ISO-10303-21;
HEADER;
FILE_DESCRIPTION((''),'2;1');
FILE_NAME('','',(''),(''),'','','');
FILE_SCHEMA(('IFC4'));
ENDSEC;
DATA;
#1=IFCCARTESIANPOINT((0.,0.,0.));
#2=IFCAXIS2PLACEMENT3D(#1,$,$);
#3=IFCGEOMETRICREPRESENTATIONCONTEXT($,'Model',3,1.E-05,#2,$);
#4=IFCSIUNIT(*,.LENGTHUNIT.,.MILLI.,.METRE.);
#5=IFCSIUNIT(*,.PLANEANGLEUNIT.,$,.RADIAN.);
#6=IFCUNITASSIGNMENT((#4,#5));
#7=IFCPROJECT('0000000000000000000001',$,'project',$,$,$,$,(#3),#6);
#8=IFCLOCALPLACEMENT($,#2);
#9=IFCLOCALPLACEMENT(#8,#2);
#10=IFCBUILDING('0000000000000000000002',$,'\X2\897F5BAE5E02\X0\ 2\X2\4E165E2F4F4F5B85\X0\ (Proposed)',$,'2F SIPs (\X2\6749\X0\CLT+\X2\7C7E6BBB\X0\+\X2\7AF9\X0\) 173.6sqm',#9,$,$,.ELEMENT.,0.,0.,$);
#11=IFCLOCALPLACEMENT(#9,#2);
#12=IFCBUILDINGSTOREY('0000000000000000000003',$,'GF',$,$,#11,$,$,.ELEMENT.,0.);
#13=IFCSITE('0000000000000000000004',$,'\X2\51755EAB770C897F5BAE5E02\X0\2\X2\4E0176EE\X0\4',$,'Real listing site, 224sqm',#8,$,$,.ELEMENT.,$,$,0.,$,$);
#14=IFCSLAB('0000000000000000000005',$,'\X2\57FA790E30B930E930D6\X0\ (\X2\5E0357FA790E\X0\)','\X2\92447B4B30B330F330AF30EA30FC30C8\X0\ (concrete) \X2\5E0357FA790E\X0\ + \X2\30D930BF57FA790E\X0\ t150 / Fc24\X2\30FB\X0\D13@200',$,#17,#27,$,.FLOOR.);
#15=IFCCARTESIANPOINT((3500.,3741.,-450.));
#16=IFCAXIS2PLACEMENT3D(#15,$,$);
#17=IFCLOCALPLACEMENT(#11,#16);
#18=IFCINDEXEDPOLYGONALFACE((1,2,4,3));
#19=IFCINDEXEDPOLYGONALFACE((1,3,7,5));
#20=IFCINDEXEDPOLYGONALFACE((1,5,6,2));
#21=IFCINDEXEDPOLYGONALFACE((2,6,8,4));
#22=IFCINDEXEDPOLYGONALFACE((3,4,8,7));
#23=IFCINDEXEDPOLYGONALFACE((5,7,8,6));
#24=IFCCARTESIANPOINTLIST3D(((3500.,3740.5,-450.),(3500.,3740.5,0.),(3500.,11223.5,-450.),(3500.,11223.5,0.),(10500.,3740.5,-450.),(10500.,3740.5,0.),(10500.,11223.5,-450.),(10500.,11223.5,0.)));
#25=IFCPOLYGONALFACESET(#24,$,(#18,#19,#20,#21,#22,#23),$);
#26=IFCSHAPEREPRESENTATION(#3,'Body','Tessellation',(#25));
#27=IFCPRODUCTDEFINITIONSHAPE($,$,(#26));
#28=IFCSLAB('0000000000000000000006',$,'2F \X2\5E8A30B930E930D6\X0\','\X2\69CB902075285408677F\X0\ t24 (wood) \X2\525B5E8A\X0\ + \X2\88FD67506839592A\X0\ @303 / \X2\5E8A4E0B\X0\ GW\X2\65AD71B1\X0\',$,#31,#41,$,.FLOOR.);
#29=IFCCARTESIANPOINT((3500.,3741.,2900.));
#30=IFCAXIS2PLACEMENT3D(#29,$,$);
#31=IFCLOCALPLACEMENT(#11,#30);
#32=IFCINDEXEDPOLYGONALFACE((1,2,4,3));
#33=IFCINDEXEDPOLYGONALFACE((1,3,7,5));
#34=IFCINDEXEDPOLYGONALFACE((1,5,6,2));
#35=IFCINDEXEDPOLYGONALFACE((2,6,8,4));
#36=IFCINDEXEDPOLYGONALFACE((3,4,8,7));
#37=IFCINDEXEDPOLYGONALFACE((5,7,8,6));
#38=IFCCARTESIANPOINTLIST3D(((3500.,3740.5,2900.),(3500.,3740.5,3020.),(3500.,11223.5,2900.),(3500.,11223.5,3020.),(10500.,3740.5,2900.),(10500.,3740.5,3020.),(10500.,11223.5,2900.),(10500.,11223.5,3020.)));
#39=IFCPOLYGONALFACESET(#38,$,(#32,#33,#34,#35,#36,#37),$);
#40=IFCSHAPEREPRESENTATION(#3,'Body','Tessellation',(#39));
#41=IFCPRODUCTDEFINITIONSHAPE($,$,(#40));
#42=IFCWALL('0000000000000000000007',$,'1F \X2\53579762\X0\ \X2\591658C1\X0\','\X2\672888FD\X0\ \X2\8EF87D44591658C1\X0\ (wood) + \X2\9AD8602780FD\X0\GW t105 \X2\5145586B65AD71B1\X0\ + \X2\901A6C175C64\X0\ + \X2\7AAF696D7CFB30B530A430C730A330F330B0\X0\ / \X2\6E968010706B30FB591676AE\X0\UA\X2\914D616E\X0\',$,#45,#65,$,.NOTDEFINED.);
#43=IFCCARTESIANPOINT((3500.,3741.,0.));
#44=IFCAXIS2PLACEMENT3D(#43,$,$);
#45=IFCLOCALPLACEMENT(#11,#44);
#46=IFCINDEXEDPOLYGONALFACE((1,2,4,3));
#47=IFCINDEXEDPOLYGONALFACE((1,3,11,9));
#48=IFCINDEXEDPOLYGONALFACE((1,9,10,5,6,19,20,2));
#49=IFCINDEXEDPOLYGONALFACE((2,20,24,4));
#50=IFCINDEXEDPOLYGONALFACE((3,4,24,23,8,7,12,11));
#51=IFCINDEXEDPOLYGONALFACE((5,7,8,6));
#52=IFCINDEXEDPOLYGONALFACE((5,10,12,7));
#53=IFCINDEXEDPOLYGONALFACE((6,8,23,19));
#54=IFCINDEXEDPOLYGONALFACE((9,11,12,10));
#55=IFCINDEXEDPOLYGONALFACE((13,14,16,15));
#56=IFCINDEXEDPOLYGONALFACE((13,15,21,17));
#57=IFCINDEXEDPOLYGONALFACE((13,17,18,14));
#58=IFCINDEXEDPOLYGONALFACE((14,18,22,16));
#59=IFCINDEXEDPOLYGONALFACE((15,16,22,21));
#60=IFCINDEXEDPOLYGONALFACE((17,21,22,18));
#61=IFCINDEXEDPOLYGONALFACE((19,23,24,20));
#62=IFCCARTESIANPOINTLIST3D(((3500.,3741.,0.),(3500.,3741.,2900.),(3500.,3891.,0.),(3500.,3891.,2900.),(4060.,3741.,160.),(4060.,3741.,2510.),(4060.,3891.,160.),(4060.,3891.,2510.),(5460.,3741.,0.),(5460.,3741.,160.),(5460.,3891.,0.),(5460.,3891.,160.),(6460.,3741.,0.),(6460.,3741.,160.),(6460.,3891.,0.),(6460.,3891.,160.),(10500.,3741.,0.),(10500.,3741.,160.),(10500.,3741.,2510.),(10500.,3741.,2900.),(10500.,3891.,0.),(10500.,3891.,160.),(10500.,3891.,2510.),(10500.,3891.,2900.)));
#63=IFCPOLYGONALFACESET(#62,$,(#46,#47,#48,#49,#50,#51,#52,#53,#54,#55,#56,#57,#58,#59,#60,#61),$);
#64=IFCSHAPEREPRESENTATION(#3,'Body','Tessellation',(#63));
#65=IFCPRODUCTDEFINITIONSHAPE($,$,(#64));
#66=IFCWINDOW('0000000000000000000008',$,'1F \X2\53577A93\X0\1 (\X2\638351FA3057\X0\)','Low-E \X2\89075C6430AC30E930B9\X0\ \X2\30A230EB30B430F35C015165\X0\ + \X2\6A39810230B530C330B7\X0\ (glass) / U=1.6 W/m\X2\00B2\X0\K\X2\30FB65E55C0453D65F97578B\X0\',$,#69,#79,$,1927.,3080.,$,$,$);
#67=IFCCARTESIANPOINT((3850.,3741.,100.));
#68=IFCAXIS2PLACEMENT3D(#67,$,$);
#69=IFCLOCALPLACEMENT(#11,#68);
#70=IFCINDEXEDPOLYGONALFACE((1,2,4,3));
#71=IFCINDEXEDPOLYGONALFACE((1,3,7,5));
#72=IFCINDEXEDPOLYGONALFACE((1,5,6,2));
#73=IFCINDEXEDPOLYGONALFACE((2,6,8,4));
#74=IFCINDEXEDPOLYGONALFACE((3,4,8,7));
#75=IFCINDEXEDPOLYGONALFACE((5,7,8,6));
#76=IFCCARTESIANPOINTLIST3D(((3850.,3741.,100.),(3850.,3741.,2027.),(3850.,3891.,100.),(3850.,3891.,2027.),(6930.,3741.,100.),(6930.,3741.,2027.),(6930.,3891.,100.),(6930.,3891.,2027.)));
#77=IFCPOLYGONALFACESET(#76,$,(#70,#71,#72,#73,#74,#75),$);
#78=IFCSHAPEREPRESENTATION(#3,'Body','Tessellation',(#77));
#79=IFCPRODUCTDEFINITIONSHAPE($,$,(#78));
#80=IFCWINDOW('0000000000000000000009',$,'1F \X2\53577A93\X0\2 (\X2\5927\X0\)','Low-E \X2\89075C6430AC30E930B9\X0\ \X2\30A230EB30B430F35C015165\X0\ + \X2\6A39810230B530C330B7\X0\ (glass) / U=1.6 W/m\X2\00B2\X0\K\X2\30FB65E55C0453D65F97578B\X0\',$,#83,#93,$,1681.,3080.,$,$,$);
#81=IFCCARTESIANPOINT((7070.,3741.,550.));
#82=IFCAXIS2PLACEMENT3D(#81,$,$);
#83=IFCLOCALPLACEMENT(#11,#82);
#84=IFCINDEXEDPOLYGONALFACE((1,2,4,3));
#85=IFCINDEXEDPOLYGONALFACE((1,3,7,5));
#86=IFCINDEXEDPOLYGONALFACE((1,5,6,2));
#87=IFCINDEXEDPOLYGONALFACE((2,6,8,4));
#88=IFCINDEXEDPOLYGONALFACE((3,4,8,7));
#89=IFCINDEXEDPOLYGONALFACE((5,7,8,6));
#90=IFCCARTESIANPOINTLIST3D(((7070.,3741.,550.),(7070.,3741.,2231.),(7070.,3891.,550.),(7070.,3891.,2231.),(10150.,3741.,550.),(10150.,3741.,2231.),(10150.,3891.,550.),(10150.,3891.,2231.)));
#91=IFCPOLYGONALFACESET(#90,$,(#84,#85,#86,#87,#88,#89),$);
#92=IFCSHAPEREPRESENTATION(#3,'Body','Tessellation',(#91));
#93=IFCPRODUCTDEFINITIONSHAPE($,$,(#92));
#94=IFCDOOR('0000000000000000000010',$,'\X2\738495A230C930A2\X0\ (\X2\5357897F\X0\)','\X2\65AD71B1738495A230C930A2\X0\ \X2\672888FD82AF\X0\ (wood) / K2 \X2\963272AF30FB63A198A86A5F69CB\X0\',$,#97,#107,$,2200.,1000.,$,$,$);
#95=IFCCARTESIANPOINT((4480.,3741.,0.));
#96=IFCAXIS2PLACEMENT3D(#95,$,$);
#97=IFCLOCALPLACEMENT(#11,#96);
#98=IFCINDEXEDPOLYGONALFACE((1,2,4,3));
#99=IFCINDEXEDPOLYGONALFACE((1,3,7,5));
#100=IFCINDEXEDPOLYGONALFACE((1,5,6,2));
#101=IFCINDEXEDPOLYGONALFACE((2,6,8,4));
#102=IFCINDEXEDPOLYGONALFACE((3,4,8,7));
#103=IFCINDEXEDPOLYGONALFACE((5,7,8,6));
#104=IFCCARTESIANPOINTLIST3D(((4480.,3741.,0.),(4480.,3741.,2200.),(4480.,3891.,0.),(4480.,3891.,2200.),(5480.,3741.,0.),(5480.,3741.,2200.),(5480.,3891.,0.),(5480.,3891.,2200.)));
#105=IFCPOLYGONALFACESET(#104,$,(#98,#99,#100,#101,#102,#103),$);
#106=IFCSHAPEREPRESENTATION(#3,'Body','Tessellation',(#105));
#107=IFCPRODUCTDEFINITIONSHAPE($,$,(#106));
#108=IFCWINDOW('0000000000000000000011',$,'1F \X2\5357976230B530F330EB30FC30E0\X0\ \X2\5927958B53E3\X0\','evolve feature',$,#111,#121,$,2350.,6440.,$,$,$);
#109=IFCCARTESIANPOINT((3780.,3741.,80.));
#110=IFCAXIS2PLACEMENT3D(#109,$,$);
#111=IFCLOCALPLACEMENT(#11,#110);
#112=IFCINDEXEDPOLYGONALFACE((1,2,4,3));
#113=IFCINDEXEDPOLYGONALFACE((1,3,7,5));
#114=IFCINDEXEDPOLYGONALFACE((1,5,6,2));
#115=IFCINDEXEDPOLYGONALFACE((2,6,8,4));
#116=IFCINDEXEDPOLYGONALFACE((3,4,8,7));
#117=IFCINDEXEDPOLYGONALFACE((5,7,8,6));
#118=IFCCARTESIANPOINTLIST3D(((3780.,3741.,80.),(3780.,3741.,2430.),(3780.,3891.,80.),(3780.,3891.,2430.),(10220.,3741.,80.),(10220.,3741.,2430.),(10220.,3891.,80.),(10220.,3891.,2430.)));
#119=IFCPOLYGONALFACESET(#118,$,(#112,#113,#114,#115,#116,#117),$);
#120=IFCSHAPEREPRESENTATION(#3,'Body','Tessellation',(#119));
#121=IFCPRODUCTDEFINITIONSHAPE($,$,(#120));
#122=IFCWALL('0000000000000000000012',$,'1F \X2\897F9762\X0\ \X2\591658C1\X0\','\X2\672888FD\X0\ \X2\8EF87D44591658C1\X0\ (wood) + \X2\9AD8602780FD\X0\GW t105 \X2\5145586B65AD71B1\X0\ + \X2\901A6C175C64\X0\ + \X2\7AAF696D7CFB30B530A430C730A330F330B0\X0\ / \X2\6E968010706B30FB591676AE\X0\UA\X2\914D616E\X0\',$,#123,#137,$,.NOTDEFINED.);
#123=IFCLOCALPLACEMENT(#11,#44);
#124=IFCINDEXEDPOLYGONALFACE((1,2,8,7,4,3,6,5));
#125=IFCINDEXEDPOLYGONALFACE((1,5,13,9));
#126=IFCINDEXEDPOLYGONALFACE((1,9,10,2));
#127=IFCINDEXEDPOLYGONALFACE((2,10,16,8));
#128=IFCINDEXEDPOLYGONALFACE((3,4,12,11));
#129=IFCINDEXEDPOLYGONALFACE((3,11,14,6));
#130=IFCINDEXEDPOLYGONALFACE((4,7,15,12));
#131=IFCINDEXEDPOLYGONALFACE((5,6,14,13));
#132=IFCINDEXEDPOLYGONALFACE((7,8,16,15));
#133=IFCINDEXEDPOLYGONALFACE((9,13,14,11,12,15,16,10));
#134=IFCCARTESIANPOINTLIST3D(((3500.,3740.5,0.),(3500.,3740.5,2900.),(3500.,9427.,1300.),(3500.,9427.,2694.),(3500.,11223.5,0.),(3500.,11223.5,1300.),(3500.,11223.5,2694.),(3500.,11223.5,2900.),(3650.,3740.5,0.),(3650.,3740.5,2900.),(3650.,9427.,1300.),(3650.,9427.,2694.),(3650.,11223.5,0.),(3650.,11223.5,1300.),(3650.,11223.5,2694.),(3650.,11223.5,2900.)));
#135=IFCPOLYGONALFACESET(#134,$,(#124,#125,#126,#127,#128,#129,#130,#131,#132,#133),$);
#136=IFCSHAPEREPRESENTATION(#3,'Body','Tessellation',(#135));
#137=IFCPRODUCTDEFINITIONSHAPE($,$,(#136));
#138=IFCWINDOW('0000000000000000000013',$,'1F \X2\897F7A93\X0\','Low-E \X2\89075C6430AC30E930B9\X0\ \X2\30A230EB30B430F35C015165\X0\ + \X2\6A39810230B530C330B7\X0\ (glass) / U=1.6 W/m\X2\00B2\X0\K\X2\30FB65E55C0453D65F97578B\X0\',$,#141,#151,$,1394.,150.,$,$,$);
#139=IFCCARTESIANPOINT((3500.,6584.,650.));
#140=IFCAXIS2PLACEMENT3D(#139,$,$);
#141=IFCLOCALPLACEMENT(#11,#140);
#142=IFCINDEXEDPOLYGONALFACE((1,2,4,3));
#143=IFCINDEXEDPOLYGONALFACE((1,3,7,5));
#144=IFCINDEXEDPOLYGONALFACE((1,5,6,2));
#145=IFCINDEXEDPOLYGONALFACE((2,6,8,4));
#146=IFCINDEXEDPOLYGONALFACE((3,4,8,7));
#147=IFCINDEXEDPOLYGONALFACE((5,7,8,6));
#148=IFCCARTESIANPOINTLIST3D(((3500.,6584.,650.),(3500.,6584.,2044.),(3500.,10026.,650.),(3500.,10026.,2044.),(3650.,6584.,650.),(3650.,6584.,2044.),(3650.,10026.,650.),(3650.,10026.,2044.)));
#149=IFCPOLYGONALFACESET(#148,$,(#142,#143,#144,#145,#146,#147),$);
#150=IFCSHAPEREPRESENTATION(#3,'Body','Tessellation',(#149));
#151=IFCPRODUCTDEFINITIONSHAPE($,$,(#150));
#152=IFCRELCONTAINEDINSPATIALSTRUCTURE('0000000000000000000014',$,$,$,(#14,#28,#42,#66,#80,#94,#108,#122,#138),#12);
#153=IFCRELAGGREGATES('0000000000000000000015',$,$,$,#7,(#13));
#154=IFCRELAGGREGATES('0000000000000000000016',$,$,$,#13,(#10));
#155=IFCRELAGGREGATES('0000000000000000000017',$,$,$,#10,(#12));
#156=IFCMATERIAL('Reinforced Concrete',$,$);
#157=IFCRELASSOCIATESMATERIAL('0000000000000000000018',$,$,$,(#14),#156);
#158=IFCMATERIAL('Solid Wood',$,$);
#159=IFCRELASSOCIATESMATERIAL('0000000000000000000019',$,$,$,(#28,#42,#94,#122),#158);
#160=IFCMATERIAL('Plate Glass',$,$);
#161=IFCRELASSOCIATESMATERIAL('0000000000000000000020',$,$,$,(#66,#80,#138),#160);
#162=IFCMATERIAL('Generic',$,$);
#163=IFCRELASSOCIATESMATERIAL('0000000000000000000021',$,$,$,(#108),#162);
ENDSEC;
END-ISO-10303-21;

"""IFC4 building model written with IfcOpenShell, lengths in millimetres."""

from ifc_helpers import new_model, si_unit, frame, frame_2d, origin, place, context, project, spatial, rectangle, extrude, material, element, fill, save


model = new_model("IFC4")

# Units and contexts
model_context = context("Model", 3, precision=1e-05, world=origin())
ifc_project = project(units=[si_unit("LENGTHUNIT", "METRE", prefix="MILLI"), si_unit("PLANEANGLEUNIT", "RADIAN")], contexts=[model_context])

# Site, building, storey
site_placement = place(None, origin())
site = spatial("IfcSite", under=ifc_project, at=site_placement, Name="兵庫県西宮市2丁目4", ObjectType="Real listing site, 224sqm", CompositionType="ELEMENT", RefElevation=0.0)
building_placement = place(site_placement, origin())
building = spatial("IfcBuilding", under=site, at=building_placement, Name="西宮市 2世帯住宅 (Proposed)", ObjectType="2F SIPs (杉CLT+籾殻+竹) 173.6sqm", CompositionType="ELEMENT", ElevationOfRefHeight=0.0, ElevationOfTerrain=0.0)
storey_placement = place(building_placement, origin())
storey = spatial("IfcBuildingStorey", under=building, at=storey_placement, Name="GF", CompositionType="ELEMENT", Elevation=0.0)

# Slabs
ifc_material_1 = material(Name="Reinforced Concrete")
slab_1_placement = place(storey_placement, frame((3500.0, 3741.0, -450.0)))
element("IfcSlab", 1, at=slab_1_placement, inside=storey, material=ifc_material_1, Name="基礎スラブ (布基礎)", Description="鉄筋コンクリート (concrete) 布基礎 + ベタ基礎 t150 / Fc24・D13@200", PredefinedType="FLOOR", context=model_context, shape_type="SweptSolid", body=[
    extrude(rectangle(XDim=7000.0, YDim=7483.0, at=frame_2d((3500.0, 3741.0))), frame((3500.0, 3741.0, -450.0)), (0.0, 0.0, 1.0), 450.0),
])
ifc_material_2 = material(Name="Solid Wood")
slab_2_placement = place(storey_placement, frame((3500.0, 3741.0, 2900.0)))
element("IfcSlab", 2, at=slab_2_placement, inside=storey, material=ifc_material_2, Name="2F 床スラブ", Description="構造用合板 t24 (wood) 剛床 + 製材根太 @303 / 床下 GW断熱", PredefinedType="FLOOR", context=model_context, shape_type="SweptSolid", body=[
    extrude(rectangle(XDim=7000.0, YDim=7483.0, at=frame_2d((3500.0, 3741.0))), frame((3500.0, 3741.0, 2900.0)), (0.0, 0.0, 1.0), 120.0),
])
ifc_material_3 = material(Name="Generic")

# Wall, openings, windows, door
wall_1_placement = place(storey_placement, frame((3500.0, 3741.0, 0.0)))
wall_1 = element("IfcWall", 3, at=wall_1_placement, inside=storey, material=ifc_material_2, Name="1F 南面 外壁", Description="木製 軸組外壁 (wood) + 高性能GW t105 充填断熱 + 通気層 + 窯業系サイディング / 準耐火・外皮UA配慮", PredefinedType="NOTDEFINED", context=model_context, shape_type="SweptSolid", body=[
    extrude(rectangle(XDim=7000.0, YDim=150.0, at=frame_2d((3500.0, 75.0))), frame((3500.0, 3741.0, 0.0)), (0.0, 0.0, 1.0), 2900.0),
])
opening_1_placement = place(storey_placement, frame((3850.0, 3741.0, 100.0)))
opening_1 = element("IfcOpeningElement", 4, at=opening_1_placement, cuts=wall_1, PredefinedType="NOTDEFINED", context=model_context, shape_type="SweptSolid", body=[
    extrude(rectangle(XDim=3080.0, YDim=150.0, at=frame_2d((1540.0, 75.0))), frame((3850.0, 3741.0, 100.0)), (0.0, 0.0, 1.0), 1927.0),
])
opening_2_placement = place(storey_placement, frame((7070.0, 3741.0, 550.0)))
opening_2 = element("IfcOpeningElement", 5, at=opening_2_placement, cuts=wall_1, PredefinedType="NOTDEFINED", context=model_context, shape_type="SweptSolid", body=[
    extrude(rectangle(XDim=3080.0, YDim=150.0, at=frame_2d((1540.0, 75.0))), frame((7070.0, 3741.0, 550.0)), (0.0, 0.0, 1.0), 1681.0),
])
opening_3_placement = place(storey_placement, frame((4480.0, 3741.0, 0.0)))
opening_3 = element("IfcOpeningElement", 6, at=opening_3_placement, cuts=wall_1, PredefinedType="NOTDEFINED", context=model_context, shape_type="SweptSolid", body=[
    extrude(rectangle(XDim=1000.0, YDim=150.0, at=frame_2d((500.0, 75.0))), frame((4480.0, 3741.0, 0.0)), (0.0, 0.0, 1.0), 2200.0),
])
opening_4_placement = place(storey_placement, frame((3780.0, 3741.0, 80.0)))
opening_4 = element("IfcOpeningElement", 7, at=opening_4_placement, cuts=wall_1, PredefinedType="NOTDEFINED", context=model_context, shape_type="SweptSolid", body=[
    extrude(rectangle(XDim=6440.0, YDim=150.0, at=frame_2d((3220.0, 75.0))), frame((3780.0, 3741.0, 80.0)), (0.0, 0.0, 1.0), 2350.0),
])
ifc_material_4 = material(Name="Plate Glass")
window_1_placement = place(storey_placement, frame((3850.0, 3741.0, 100.0)))
window_1 = element("IfcWindow", 8, at=window_1_placement, inside=storey, material=ifc_material_4, Name="1F 南窓1 (掃出し)", Description="Low-E 複層ガラス アルゴン封入 + 樹脂サッシ (glass) / U=1.6 W/m²K・日射取得型", OverallHeight=1927.0, OverallWidth=3080.0, context=model_context, shape_type="SweptSolid", body=[
    extrude(rectangle(XDim=3080.0, YDim=150.0, at=frame_2d((1540.0, 75.0))), frame((3850.0, 3741.0, 100.0)), (0.0, 0.0, 1.0), 1927.0),
])
fill(opening_1, window_1)
window_2_placement = place(storey_placement, frame((7070.0, 3741.0, 550.0)))
window_2 = element("IfcWindow", 9, at=window_2_placement, inside=storey, material=ifc_material_4, Name="1F 南窓2 (大)", Description="Low-E 複層ガラス アルゴン封入 + 樹脂サッシ (glass) / U=1.6 W/m²K・日射取得型", OverallHeight=1681.0, OverallWidth=3080.0, context=model_context, shape_type="SweptSolid", body=[
    extrude(rectangle(XDim=3080.0, YDim=150.0, at=frame_2d((1540.0, 75.0))), frame((7070.0, 3741.0, 550.0)), (0.0, 0.0, 1.0), 1681.0),
])
fill(opening_2, window_2)
door_placement = place(storey_placement, frame((4480.0, 3741.0, 0.0)))
door = element("IfcDoor", 10, at=door_placement, inside=storey, material=ifc_material_2, Name="玄関ドア (南西)", Description="断熱玄関ドア 木製芯 (wood) / K2 防犯・採風機構", OverallHeight=2200.0, OverallWidth=1000.0, context=model_context, shape_type="SweptSolid", body=[
    extrude(rectangle(XDim=1000.0, YDim=150.0, at=frame_2d((500.0, 75.0))), frame((4480.0, 3741.0, 0.0)), (0.0, 0.0, 1.0), 2200.0),
])
fill(opening_3, door)
window_3_placement = place(storey_placement, frame((3780.0, 3741.0, 80.0)))
window_3 = element("IfcWindow", 11, at=window_3_placement, inside=storey, material=ifc_material_3, Name="1F 南面サンルーム 大開口", Description="evolve feature", OverallHeight=2350.0, OverallWidth=6440.0, context=model_context, shape_type="SweptSolid", body=[
    extrude(rectangle(XDim=6440.0, YDim=150.0, at=frame_2d((3220.0, 75.0))), frame((3780.0, 3741.0, 80.0)), (0.0, 0.0, 1.0), 2350.0),
])
fill(opening_4, window_3)

# Wall, opening, window
wall_2_placement = place(storey_placement, frame((3500.0, 3741.0, 0.0)))
wall_2 = element("IfcWall", 12, at=wall_2_placement, inside=storey, material=ifc_material_2, Name="1F 西面 外壁", Description="木製 軸組外壁 (wood) + 高性能GW t105 充填断熱 + 通気層 + 窯業系サイディング / 準耐火・外皮UA配慮", PredefinedType="NOTDEFINED", context=model_context, shape_type="SweptSolid", body=[
    extrude(rectangle(XDim=150.0, YDim=7483.0, at=frame_2d((75.0, 3741.0))), frame((3500.0, 3741.0, 0.0)), (0.0, 0.0, 1.0), 2900.0),
])
opening_5_placement = place(storey_placement, frame((3500.0, 6584.0, 650.0)))
opening_5 = element("IfcOpeningElement", 13, at=opening_5_placement, cuts=wall_2, PredefinedType="NOTDEFINED", context=model_context, shape_type="SweptSolid", body=[
    extrude(rectangle(XDim=150.0, YDim=3442.0, at=frame_2d((75.0, 1721.0))), frame((3500.0, 6584.0, 650.0)), (0.0, 0.0, 1.0), 1394.0),
])
window_4_placement = place(storey_placement, frame((3500.0, 6584.0, 650.0)))
window_4 = element("IfcWindow", 14, at=window_4_placement, inside=storey, material=ifc_material_4, Name="1F 西窓", Description="Low-E 複層ガラス アルゴン封入 + 樹脂サッシ (glass) / U=1.6 W/m²K・日射取得型", OverallHeight=1394.0, OverallWidth=150.0, context=model_context, shape_type="SweptSolid", body=[
    extrude(rectangle(XDim=150.0, YDim=3442.0, at=frame_2d((75.0, 1721.0))), frame((3500.0, 6584.0, 650.0)), (0.0, 0.0, 1.0), 1394.0),
])
fill(opening_5, window_4)

save(model, "model.ifc")
